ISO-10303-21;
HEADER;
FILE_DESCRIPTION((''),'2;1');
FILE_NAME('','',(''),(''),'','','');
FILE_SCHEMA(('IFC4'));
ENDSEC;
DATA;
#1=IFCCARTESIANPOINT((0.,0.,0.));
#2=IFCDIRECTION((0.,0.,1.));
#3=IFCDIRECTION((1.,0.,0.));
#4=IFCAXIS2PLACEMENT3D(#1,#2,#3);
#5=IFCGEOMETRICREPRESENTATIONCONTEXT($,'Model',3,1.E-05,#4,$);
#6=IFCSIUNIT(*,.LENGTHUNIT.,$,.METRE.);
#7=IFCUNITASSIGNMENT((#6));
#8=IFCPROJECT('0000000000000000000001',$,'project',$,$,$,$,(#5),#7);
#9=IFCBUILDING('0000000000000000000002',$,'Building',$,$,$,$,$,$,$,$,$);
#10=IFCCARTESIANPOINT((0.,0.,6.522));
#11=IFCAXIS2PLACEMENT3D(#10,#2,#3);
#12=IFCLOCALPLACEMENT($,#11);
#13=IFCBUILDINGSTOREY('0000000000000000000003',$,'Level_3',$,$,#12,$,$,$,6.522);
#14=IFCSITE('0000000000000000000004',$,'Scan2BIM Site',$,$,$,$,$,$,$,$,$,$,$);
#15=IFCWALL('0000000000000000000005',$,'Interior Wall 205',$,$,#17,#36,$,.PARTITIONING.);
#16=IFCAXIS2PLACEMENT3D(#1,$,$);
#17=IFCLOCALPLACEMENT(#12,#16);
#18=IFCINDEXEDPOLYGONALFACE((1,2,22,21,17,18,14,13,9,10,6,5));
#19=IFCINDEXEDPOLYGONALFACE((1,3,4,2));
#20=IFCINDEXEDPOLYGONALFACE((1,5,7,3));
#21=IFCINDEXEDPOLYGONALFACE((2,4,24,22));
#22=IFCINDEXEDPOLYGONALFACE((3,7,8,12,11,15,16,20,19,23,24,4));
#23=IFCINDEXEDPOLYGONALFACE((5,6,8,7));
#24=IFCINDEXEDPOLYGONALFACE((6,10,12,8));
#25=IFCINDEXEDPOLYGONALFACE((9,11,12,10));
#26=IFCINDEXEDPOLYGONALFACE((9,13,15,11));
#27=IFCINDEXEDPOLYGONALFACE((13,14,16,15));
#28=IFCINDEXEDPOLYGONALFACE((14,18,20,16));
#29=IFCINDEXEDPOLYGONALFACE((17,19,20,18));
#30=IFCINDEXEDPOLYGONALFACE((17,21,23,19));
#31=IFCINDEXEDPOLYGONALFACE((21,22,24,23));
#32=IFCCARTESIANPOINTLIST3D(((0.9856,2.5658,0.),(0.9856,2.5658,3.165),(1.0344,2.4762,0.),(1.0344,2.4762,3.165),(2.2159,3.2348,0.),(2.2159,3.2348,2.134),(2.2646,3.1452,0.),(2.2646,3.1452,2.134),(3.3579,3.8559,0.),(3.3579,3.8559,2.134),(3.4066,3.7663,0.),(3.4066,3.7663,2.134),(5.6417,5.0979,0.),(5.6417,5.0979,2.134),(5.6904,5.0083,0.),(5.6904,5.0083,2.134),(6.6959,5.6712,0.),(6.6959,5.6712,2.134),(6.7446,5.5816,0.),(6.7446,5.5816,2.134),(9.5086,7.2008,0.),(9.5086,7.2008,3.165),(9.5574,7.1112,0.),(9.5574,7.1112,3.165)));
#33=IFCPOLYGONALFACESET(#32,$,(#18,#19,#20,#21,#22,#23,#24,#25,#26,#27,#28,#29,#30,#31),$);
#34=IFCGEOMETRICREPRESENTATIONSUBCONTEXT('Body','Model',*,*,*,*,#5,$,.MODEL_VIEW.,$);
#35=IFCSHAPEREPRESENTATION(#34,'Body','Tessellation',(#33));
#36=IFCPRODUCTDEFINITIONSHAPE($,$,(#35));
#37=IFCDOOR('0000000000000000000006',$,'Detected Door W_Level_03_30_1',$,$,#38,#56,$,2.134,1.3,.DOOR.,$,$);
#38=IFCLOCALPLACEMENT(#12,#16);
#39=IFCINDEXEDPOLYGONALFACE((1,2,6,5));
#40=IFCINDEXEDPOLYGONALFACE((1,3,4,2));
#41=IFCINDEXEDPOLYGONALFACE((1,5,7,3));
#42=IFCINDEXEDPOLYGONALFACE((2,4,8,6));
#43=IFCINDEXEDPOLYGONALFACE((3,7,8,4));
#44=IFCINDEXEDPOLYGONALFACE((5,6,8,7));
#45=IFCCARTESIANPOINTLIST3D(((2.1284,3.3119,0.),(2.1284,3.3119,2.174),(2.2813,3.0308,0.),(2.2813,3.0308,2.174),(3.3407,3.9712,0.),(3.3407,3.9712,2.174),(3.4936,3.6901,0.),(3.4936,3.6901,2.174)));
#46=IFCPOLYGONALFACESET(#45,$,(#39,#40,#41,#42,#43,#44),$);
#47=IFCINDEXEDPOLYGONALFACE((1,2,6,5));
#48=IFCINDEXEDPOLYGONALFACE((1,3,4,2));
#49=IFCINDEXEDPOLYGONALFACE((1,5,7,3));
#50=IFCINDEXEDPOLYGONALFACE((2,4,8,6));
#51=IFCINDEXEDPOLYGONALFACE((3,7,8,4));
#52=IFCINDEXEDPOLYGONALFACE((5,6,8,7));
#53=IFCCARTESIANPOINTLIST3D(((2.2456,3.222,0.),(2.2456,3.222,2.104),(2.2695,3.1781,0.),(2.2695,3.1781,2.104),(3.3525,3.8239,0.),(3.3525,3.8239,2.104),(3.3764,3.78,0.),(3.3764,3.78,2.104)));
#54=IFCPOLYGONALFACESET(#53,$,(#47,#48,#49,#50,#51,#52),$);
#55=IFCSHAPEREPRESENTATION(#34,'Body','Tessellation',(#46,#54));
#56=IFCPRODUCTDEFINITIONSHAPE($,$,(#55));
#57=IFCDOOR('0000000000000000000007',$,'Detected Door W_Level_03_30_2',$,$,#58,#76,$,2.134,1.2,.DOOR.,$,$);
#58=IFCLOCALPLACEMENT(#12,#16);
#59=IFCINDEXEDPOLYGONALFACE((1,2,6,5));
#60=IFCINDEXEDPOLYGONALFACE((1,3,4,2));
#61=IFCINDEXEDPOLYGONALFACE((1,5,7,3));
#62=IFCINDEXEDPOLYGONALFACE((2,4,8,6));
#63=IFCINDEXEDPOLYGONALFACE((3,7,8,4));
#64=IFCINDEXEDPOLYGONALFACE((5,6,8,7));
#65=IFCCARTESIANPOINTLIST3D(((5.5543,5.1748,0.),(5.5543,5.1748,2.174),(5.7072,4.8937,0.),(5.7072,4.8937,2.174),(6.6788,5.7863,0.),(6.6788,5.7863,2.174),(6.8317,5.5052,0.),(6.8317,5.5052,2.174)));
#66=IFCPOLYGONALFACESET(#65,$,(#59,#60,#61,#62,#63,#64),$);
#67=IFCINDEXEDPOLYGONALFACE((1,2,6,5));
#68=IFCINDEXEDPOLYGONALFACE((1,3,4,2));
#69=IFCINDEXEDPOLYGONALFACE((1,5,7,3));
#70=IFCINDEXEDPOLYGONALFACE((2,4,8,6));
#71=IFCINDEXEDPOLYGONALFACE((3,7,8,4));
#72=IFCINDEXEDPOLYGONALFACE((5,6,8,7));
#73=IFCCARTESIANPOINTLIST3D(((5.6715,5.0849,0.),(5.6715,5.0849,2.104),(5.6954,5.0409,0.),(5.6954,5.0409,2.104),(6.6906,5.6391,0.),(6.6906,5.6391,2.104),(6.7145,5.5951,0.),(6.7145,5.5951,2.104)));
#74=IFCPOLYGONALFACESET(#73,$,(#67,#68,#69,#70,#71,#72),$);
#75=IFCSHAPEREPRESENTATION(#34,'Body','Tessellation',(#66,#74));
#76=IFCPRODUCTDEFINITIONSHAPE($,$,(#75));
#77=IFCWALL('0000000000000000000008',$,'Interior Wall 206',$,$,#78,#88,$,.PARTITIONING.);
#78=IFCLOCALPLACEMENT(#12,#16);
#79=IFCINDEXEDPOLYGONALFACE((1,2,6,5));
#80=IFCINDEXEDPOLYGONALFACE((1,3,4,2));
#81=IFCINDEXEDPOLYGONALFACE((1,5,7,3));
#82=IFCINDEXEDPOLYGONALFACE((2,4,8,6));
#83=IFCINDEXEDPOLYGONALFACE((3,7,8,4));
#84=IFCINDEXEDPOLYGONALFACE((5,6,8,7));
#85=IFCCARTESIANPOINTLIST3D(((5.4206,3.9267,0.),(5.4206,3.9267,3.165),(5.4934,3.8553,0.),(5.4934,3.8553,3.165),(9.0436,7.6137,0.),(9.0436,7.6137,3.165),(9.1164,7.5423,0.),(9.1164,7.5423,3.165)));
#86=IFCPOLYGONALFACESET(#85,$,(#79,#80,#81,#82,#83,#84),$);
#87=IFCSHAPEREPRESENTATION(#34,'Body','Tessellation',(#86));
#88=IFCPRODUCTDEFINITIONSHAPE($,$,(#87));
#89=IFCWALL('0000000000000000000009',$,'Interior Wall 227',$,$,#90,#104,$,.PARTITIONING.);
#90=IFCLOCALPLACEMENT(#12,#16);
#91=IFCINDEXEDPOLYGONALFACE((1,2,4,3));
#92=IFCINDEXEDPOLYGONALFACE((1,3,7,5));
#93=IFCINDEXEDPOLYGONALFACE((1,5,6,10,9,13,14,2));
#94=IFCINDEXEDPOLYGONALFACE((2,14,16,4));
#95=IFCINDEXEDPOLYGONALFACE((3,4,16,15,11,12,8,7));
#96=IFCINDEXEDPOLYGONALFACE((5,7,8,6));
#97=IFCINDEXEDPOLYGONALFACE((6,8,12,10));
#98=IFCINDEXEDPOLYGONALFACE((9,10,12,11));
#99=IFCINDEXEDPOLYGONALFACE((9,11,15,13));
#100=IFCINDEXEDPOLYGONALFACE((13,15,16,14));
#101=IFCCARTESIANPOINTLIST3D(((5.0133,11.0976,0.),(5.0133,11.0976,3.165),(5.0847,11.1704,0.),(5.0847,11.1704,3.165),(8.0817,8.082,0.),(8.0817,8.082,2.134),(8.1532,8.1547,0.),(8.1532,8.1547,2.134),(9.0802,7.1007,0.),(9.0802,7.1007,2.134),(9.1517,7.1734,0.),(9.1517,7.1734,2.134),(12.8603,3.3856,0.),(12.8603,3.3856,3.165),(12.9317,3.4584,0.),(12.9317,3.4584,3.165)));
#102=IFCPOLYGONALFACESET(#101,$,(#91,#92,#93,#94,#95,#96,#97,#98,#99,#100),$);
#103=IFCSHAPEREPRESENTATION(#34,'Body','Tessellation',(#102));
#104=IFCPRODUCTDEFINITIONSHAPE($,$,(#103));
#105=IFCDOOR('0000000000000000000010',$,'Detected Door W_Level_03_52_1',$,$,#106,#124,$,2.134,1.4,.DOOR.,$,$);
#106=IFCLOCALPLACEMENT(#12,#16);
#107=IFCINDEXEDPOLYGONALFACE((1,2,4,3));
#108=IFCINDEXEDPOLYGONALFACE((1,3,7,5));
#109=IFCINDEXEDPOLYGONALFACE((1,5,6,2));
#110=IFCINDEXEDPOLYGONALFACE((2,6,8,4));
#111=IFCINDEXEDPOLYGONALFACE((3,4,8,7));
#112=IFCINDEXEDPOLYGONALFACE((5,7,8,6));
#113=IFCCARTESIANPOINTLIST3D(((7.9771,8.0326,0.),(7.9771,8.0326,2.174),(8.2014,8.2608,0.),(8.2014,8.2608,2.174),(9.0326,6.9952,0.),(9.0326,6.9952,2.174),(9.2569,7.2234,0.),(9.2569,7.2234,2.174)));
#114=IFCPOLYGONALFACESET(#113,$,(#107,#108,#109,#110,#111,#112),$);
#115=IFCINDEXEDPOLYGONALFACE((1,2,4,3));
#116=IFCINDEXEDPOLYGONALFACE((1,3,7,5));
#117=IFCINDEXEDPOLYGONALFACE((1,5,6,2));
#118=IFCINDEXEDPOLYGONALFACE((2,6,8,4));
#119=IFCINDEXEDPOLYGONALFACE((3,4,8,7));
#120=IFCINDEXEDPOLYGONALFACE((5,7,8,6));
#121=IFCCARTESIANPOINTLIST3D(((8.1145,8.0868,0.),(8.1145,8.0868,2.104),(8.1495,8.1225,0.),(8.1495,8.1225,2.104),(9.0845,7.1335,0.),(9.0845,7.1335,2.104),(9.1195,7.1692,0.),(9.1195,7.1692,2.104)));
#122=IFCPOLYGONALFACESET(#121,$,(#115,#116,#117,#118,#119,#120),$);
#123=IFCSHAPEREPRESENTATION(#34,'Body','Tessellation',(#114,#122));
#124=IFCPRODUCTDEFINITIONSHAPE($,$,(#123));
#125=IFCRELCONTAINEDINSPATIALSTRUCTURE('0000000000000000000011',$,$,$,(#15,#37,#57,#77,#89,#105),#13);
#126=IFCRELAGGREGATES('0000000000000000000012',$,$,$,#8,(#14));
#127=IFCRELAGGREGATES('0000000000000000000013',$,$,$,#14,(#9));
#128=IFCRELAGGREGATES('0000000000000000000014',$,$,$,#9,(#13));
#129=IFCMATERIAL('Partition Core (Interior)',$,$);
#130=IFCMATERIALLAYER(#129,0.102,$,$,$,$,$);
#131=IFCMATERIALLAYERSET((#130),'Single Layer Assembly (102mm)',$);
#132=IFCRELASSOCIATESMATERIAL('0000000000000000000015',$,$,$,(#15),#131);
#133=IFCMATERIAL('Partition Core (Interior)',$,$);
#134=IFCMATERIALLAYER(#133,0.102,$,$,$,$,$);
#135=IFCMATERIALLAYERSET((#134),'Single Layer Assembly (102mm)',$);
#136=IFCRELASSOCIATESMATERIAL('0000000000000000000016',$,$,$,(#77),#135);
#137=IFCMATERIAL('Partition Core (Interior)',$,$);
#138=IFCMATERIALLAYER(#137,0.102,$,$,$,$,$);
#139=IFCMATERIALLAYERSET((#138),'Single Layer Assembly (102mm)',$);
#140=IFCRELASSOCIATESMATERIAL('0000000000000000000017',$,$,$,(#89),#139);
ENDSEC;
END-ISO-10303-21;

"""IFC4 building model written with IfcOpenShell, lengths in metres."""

from ifc_helpers import new_model, si_unit, frame, origin, origin_with_axes, place, context, subcontext, project, spatial, rectangle, extrude, material, layer, layer_set, element, fill, save


model = new_model("IFC4")

# Units and contexts
model_context = context("Model", 3, precision=1e-05, world=origin_with_axes())
body_context = subcontext(model_context, "Body", "Model", "MODEL_VIEW")
ifc_project = project(units=[si_unit("LENGTHUNIT", "METRE")], contexts=[model_context])

# Site, building, storey
site = spatial("IfcSite", under=ifc_project, Name="Scan2BIM Site")
building = spatial("IfcBuilding", under=site, Name="Building")
storey_placement = place(None, frame((0.0, 0.0, 6.522), z_axis=(0.0, 0.0, 1.0), x_axis=(1.0, 0.0, 0.0)))
storey = spatial("IfcBuildingStorey", under=building, at=storey_placement, Name="Level_3", Elevation=6.522)

# Wall, openings, doors
ifc_material_1 = material(Name="Partition Core (Interior)")
ifc_layer_1 = layer(ifc_material_1, 0.102)
ifc_layer_set_1 = layer_set([ifc_layer_1], Name="Single Layer Assembly (102mm)")
wall_1_placement = place(storey_placement, frame((5.2715, 4.8385, 0.0), z_axis=(0.0, 0.0, 1.0), x_axis=(0.878498, 0.477747, 0.0)))
wall_1 = element("IfcWall", 1, at=wall_1_placement, inside=storey, material=ifc_layer_set_1, Name="Interior Wall 205", PredefinedType="PARTITIONING", context=body_context, shape_type="SweptSolid", body=[
    extrude(rectangle(XDim=9.7018, YDim=0.102), origin(), (0.0, 0.0, 1.0), 3.165),
])
opening_1_placement = place(None, frame((2.811, 3.501, 6.522), z_axis=(0.0, 0.0, 1.0), x_axis=(0.878498, 0.477747, 0.0)))
opening_1 = element("IfcOpeningElement", 2, at=opening_1_placement, cuts=wall_1, PredefinedType="OPENING", context=body_context, shape_type="SweptSolid", body=[
    extrude(rectangle(XDim=1.3, YDim=0.202), origin(), (0.0, 0.0, 1.0), 2.134),
])
opening_2_placement = place(None, frame((6.193, 5.34, 6.522), z_axis=(0.0, 0.0, 1.0), x_axis=(0.878498, 0.477747, 0.0)))
opening_2 = element("IfcOpeningElement", 3, at=opening_2_placement, cuts=wall_1, PredefinedType="OPENING", context=body_context, shape_type="SweptSolid", body=[
    extrude(rectangle(XDim=1.2, YDim=0.202), origin(), (0.0, 0.0, 1.0), 2.134),
])
door_1_placement = place(opening_1_placement, frame((0.0, 0.0, 0.0), z_axis=(0.0, 0.0, 1.0), x_axis=(1.0, 0.0, 0.0)))
door_1 = element("IfcDoor", 4, at=door_1_placement, inside=storey, Name="Detected Door W_Level_03_30_1", OverallHeight=2.134, OverallWidth=1.3, PredefinedType="DOOR", context=body_context, shape_type="SweptSolid", body=[
    extrude(rectangle(XDim=1.38, YDim=0.32), origin(), (0.0, 0.0, 1.0), 2.174),
    extrude(rectangle(XDim=1.26, YDim=0.05), origin(), (0.0, 0.0, 1.0), 2.104),
])
fill(opening_1, door_1)
door_2_placement = place(opening_2_placement, frame((0.0, 0.0, 0.0), z_axis=(0.0, 0.0, 1.0), x_axis=(1.0, 0.0, 0.0)))
door_2 = element("IfcDoor", 5, at=door_2_placement, inside=storey, Name="Detected Door W_Level_03_30_2", OverallHeight=2.134, OverallWidth=1.2, PredefinedType="DOOR", context=body_context, shape_type="SweptSolid", body=[
    extrude(rectangle(XDim=1.28, YDim=0.32), origin(), (0.0, 0.0, 1.0), 2.174),
    extrude(rectangle(XDim=1.16, YDim=0.05), origin(), (0.0, 0.0, 1.0), 2.104),
])
fill(opening_2, door_2)

# Wall
ifc_material_2 = material(Name="Partition Core (Interior)")
ifc_layer_2 = layer(ifc_material_2, 0.102)
ifc_layer_set_2 = layer_set([ifc_layer_2], Name="Single Layer Assembly (102mm)")
wall_2_placement = place(storey_placement, frame((7.2685, 5.7345, 0.0), z_axis=(0.0, 0.0, 1.0), x_axis=(-0.700889, -0.71327, 0.0)))
element("IfcWall", 6, at=wall_2_placement, inside=storey, material=ifc_layer_set_2, Name="Interior Wall 206", PredefinedType="PARTITIONING", context=body_context, shape_type="SweptSolid", body=[
    extrude(rectangle(XDim=5.1691, YDim=0.102), origin(), (0.0, 0.0, 1.0), 3.165),
])

# Wall, opening, door
ifc_material_3 = material(Name="Partition Core (Interior)")
ifc_layer_3 = layer(ifc_material_3, 0.102)
ifc_layer_set_3 = layer_set([ifc_layer_3], Name="Single Layer Assembly (102mm)")
wall_3_placement = place(storey_placement, frame((8.9725, 7.278, 0.0), z_axis=(0.0, 0.0, 1.0), x_axis=(-0.713215, 0.700945, 0.0)))
wall_3 = element("IfcWall", 7, at=wall_3_placement, inside=storey, material=ifc_layer_set_3, Name="Interior Wall 227", PredefinedType="PARTITIONING", context=body_context, shape_type="SweptSolid", body=[
    extrude(rectangle(XDim=11.0023, YDim=0.102), origin(), (0.0, 0.0, 1.0), 3.165),
])
opening_3_placement = place(None, frame((8.617, 7.628, 6.522), z_axis=(0.0, 0.0, 1.0), x_axis=(-0.713215, 0.700945, 0.0)))
opening_3 = element("IfcOpeningElement", 8, at=opening_3_placement, cuts=wall_3, PredefinedType="OPENING", context=body_context, shape_type="SweptSolid", body=[
    extrude(rectangle(XDim=1.4, YDim=0.202), origin(), (0.0, 0.0, 1.0), 2.134),
])
door_3_placement = place(opening_3_placement, frame((0.0, 0.0, 0.0), z_axis=(0.0, 0.0, 1.0), x_axis=(1.0, 0.0, 0.0)))
door_3 = element("IfcDoor", 9, at=door_3_placement, inside=storey, Name="Detected Door W_Level_03_52_1", OverallHeight=2.134, OverallWidth=1.4, PredefinedType="DOOR", context=body_context, shape_type="SweptSolid", body=[
    extrude(rectangle(XDim=1.48, YDim=0.32), origin(), (0.0, 0.0, 1.0), 2.174),
    extrude(rectangle(XDim=1.36, YDim=0.05), origin(), (0.0, 0.0, 1.0), 2.104),
])
fill(opening_3, door_3)

save(model, "model.ifc")
